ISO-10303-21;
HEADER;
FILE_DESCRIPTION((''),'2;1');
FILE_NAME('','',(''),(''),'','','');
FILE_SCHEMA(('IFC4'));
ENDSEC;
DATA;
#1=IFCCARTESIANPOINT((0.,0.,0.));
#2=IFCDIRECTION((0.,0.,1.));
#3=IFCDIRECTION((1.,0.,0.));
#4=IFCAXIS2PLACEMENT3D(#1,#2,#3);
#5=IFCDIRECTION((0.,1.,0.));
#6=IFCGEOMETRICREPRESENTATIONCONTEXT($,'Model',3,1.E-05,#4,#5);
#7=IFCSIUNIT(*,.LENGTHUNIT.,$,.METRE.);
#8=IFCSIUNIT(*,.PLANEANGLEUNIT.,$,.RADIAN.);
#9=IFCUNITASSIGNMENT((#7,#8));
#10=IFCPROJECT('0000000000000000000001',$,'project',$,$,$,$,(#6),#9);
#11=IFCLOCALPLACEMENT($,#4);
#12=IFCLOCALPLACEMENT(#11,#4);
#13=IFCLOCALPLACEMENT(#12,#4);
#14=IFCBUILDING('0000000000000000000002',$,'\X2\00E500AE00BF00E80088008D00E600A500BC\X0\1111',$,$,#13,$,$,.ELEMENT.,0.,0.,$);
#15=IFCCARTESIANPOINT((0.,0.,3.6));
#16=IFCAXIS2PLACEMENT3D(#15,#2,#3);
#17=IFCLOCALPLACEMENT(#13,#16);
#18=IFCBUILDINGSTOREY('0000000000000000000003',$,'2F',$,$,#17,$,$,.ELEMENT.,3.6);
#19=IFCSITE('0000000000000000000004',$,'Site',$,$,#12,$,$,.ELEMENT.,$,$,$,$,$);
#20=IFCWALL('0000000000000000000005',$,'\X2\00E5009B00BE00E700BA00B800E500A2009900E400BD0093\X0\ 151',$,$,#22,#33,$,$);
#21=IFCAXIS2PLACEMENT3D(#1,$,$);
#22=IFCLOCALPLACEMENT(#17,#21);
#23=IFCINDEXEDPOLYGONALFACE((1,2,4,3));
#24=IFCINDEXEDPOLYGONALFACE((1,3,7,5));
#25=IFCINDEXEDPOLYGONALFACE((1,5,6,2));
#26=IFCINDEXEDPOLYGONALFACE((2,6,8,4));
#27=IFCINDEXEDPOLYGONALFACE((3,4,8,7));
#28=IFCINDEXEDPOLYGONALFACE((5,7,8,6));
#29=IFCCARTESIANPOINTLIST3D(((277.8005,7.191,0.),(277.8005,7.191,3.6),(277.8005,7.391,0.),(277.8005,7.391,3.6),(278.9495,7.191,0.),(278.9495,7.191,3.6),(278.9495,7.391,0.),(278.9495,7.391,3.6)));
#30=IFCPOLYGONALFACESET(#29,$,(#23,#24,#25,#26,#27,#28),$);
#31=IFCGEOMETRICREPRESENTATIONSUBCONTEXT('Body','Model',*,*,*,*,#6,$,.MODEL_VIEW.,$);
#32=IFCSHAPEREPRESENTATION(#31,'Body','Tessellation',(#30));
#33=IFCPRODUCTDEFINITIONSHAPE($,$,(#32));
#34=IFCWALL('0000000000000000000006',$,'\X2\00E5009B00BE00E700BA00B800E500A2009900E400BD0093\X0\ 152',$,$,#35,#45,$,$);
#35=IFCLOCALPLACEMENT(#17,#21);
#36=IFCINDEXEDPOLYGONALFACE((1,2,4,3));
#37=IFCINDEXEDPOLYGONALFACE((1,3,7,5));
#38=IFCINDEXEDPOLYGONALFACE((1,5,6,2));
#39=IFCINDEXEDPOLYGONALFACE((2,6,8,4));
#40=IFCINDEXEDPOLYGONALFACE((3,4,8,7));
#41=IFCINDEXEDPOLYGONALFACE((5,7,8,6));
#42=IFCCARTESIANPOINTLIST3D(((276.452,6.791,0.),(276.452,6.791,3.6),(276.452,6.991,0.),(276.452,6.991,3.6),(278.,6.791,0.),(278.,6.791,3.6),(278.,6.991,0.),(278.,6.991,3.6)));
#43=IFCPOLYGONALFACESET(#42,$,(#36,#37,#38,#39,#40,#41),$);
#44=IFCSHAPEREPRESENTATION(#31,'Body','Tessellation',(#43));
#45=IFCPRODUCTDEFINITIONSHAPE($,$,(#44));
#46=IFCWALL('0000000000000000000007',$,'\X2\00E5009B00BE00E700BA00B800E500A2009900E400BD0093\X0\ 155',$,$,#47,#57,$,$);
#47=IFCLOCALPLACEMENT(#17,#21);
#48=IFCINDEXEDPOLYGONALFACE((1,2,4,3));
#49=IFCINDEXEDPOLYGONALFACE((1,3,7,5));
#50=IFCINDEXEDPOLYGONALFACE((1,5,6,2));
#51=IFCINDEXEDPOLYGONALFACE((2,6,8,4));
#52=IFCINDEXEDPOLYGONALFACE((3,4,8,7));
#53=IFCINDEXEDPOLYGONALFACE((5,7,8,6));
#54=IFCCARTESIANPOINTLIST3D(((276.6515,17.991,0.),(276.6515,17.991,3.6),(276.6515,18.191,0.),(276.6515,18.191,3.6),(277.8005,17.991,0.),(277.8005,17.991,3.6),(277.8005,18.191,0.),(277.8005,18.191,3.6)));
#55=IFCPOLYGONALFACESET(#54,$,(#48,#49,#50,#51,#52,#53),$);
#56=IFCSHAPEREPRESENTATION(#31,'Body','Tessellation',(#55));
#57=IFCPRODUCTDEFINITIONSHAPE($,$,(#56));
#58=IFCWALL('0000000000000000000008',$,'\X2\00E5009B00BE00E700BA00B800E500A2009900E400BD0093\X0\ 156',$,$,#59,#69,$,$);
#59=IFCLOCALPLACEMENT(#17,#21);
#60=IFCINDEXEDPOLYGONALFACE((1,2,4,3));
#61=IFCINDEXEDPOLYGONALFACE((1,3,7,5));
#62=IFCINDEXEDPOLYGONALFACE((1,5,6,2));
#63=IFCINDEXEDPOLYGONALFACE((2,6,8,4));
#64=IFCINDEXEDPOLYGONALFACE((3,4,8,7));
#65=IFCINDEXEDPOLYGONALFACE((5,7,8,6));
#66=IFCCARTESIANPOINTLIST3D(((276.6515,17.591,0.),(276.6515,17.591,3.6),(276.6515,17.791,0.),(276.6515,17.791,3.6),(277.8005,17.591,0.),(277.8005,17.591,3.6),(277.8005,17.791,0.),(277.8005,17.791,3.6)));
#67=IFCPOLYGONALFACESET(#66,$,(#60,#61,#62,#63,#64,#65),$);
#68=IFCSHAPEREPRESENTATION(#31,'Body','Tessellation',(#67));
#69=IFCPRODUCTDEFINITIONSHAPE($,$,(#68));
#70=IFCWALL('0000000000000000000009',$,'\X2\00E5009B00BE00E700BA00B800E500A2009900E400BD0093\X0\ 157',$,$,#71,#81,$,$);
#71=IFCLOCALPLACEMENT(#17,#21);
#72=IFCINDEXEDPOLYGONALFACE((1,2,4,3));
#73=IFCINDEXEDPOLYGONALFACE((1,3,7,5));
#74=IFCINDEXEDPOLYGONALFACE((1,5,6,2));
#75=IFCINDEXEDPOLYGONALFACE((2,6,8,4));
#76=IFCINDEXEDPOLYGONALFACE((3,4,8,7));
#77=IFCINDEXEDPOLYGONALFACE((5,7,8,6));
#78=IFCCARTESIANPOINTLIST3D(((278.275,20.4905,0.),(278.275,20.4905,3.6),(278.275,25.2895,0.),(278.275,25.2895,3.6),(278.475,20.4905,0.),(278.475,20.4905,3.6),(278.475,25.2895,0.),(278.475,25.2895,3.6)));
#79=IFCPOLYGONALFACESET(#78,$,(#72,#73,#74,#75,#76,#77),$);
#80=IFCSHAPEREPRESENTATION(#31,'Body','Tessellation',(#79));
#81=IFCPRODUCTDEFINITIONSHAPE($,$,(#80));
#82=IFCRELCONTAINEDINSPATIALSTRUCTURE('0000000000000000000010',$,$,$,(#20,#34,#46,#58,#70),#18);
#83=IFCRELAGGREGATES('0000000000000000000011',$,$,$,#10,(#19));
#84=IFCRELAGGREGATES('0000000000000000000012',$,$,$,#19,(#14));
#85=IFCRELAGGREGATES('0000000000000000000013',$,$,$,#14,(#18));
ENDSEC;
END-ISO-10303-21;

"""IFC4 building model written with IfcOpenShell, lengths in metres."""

from ifc_helpers import new_model, si_unit, direction, frame, frame_2d, origin_with_axes, place, context, subcontext, project, spatial, rectangle, extrude, element, save


model = new_model("IFC4")

# Units and contexts
model_context = context("Model", 3, precision=1e-05, world=origin_with_axes(), true_north=direction((0.0, 1.0, 0.0)))
body_context = subcontext(model_context, "Body", "Model", "MODEL_VIEW")
ifc_project = project(units=[si_unit("LENGTHUNIT", "METRE"), si_unit("PLANEANGLEUNIT", "RADIAN")], contexts=[model_context])

# Site, building, storey
placement = place(None, origin_with_axes())
site_placement = place(placement, origin_with_axes())
site = spatial("IfcSite", under=ifc_project, at=site_placement, Name="Site", CompositionType="ELEMENT")
building_placement = place(site_placement, origin_with_axes())
building = spatial("IfcBuilding", under=site, at=building_placement, Name="å®¿è\u0088\u008dæ¥¼1111", CompositionType="ELEMENT", ElevationOfRefHeight=0.0, ElevationOfTerrain=0.0)
storey_placement = place(building_placement, frame((0.0, 0.0, 3.6), z_axis=(0.0, 0.0, 1.0), x_axis=(1.0, 0.0, 0.0)))
storey = spatial("IfcBuildingStorey", under=building, at=storey_placement, Name="2F", CompositionType="ELEMENT", Elevation=3.6)

# Walls
wall_1_placement = place(storey_placement, frame((278.375, 7.291, 0.0), z_axis=(0.0, 0.0, 1.0), x_axis=(-1.0, 0.0, 0.0)))
element("IfcWall", 1, at=wall_1_placement, inside=storey, Name="å\u009b¾çº¸å¢\u0099ä½\u0093 151", context=body_context, shape_type="SweptSolid", body=[
    extrude(rectangle(XDim=1.149, YDim=0.2, at=frame_2d((0.0, 0.0), x_axis=(1.0, 0.0, 0.0))), frame((0.0, 0.0, 0.0), z_axis=(0.0, 0.0, 1.0)), (0.0, 0.0, 1.0), 3.6),
])
wall_2_placement = place(storey_placement, frame((277.226, 6.891, 0.0), z_axis=(0.0, 0.0, 1.0), x_axis=(1.0, 0.0, 0.0)))
element("IfcWall", 2, at=wall_2_placement, inside=storey, Name="å\u009b¾çº¸å¢\u0099ä½\u0093 152", context=body_context, shape_type="SweptSolid", body=[
    extrude(rectangle(XDim=1.548, YDim=0.2, at=frame_2d((0.0, 0.0), x_axis=(1.0, 0.0, 0.0))), frame((0.0, 0.0, 0.0), z_axis=(0.0, 0.0, 1.0)), (0.0, 0.0, 1.0), 3.6),
])
for number, where, z_axis, x_axis, name in (
    (3, (277.226, 18.091, 0.0), (0.0, 0.0, 1.0), (1.0, 0.0, 0.0), "å\u009b¾çº¸å¢\u0099ä½\u0093 155"),
    (4, (277.226, 17.691, 0.0), (0.0, 0.0, 1.0), (1.0, 0.0, 0.0), "å\u009b¾çº¸å¢\u0099ä½\u0093 156"),
):
    element("IfcWall", number, at=place(storey_placement, frame(where, z_axis=z_axis, x_axis=x_axis)), inside=storey, Name=name, context=body_context, shape_type="SweptSolid", body=[
        extrude(rectangle(XDim=1.149, YDim=0.2, at=frame_2d((0.0, 0.0), x_axis=(1.0, 0.0, 0.0))), frame((0.0, 0.0, 0.0), z_axis=(0.0, 0.0, 1.0)), (0.0, 0.0, 1.0), 3.6),
    ])
wall_3_placement = place(storey_placement, frame((278.375, 22.89, 0.0), z_axis=(0.0, 0.0, 1.0), x_axis=(0.0, -1.0, 0.0)))
element("IfcWall", 5, at=wall_3_placement, inside=storey, Name="å\u009b¾çº¸å¢\u0099ä½\u0093 157", context=body_context, shape_type="SweptSolid", body=[
    extrude(rectangle(XDim=4.799, YDim=0.2, at=frame_2d((0.0, 0.0), x_axis=(1.0, 0.0, 0.0))), frame((0.0, 0.0, 0.0), z_axis=(0.0, 0.0, 1.0)), (0.0, 0.0, 1.0), 3.6),
])

save(model, "model.ifc")
